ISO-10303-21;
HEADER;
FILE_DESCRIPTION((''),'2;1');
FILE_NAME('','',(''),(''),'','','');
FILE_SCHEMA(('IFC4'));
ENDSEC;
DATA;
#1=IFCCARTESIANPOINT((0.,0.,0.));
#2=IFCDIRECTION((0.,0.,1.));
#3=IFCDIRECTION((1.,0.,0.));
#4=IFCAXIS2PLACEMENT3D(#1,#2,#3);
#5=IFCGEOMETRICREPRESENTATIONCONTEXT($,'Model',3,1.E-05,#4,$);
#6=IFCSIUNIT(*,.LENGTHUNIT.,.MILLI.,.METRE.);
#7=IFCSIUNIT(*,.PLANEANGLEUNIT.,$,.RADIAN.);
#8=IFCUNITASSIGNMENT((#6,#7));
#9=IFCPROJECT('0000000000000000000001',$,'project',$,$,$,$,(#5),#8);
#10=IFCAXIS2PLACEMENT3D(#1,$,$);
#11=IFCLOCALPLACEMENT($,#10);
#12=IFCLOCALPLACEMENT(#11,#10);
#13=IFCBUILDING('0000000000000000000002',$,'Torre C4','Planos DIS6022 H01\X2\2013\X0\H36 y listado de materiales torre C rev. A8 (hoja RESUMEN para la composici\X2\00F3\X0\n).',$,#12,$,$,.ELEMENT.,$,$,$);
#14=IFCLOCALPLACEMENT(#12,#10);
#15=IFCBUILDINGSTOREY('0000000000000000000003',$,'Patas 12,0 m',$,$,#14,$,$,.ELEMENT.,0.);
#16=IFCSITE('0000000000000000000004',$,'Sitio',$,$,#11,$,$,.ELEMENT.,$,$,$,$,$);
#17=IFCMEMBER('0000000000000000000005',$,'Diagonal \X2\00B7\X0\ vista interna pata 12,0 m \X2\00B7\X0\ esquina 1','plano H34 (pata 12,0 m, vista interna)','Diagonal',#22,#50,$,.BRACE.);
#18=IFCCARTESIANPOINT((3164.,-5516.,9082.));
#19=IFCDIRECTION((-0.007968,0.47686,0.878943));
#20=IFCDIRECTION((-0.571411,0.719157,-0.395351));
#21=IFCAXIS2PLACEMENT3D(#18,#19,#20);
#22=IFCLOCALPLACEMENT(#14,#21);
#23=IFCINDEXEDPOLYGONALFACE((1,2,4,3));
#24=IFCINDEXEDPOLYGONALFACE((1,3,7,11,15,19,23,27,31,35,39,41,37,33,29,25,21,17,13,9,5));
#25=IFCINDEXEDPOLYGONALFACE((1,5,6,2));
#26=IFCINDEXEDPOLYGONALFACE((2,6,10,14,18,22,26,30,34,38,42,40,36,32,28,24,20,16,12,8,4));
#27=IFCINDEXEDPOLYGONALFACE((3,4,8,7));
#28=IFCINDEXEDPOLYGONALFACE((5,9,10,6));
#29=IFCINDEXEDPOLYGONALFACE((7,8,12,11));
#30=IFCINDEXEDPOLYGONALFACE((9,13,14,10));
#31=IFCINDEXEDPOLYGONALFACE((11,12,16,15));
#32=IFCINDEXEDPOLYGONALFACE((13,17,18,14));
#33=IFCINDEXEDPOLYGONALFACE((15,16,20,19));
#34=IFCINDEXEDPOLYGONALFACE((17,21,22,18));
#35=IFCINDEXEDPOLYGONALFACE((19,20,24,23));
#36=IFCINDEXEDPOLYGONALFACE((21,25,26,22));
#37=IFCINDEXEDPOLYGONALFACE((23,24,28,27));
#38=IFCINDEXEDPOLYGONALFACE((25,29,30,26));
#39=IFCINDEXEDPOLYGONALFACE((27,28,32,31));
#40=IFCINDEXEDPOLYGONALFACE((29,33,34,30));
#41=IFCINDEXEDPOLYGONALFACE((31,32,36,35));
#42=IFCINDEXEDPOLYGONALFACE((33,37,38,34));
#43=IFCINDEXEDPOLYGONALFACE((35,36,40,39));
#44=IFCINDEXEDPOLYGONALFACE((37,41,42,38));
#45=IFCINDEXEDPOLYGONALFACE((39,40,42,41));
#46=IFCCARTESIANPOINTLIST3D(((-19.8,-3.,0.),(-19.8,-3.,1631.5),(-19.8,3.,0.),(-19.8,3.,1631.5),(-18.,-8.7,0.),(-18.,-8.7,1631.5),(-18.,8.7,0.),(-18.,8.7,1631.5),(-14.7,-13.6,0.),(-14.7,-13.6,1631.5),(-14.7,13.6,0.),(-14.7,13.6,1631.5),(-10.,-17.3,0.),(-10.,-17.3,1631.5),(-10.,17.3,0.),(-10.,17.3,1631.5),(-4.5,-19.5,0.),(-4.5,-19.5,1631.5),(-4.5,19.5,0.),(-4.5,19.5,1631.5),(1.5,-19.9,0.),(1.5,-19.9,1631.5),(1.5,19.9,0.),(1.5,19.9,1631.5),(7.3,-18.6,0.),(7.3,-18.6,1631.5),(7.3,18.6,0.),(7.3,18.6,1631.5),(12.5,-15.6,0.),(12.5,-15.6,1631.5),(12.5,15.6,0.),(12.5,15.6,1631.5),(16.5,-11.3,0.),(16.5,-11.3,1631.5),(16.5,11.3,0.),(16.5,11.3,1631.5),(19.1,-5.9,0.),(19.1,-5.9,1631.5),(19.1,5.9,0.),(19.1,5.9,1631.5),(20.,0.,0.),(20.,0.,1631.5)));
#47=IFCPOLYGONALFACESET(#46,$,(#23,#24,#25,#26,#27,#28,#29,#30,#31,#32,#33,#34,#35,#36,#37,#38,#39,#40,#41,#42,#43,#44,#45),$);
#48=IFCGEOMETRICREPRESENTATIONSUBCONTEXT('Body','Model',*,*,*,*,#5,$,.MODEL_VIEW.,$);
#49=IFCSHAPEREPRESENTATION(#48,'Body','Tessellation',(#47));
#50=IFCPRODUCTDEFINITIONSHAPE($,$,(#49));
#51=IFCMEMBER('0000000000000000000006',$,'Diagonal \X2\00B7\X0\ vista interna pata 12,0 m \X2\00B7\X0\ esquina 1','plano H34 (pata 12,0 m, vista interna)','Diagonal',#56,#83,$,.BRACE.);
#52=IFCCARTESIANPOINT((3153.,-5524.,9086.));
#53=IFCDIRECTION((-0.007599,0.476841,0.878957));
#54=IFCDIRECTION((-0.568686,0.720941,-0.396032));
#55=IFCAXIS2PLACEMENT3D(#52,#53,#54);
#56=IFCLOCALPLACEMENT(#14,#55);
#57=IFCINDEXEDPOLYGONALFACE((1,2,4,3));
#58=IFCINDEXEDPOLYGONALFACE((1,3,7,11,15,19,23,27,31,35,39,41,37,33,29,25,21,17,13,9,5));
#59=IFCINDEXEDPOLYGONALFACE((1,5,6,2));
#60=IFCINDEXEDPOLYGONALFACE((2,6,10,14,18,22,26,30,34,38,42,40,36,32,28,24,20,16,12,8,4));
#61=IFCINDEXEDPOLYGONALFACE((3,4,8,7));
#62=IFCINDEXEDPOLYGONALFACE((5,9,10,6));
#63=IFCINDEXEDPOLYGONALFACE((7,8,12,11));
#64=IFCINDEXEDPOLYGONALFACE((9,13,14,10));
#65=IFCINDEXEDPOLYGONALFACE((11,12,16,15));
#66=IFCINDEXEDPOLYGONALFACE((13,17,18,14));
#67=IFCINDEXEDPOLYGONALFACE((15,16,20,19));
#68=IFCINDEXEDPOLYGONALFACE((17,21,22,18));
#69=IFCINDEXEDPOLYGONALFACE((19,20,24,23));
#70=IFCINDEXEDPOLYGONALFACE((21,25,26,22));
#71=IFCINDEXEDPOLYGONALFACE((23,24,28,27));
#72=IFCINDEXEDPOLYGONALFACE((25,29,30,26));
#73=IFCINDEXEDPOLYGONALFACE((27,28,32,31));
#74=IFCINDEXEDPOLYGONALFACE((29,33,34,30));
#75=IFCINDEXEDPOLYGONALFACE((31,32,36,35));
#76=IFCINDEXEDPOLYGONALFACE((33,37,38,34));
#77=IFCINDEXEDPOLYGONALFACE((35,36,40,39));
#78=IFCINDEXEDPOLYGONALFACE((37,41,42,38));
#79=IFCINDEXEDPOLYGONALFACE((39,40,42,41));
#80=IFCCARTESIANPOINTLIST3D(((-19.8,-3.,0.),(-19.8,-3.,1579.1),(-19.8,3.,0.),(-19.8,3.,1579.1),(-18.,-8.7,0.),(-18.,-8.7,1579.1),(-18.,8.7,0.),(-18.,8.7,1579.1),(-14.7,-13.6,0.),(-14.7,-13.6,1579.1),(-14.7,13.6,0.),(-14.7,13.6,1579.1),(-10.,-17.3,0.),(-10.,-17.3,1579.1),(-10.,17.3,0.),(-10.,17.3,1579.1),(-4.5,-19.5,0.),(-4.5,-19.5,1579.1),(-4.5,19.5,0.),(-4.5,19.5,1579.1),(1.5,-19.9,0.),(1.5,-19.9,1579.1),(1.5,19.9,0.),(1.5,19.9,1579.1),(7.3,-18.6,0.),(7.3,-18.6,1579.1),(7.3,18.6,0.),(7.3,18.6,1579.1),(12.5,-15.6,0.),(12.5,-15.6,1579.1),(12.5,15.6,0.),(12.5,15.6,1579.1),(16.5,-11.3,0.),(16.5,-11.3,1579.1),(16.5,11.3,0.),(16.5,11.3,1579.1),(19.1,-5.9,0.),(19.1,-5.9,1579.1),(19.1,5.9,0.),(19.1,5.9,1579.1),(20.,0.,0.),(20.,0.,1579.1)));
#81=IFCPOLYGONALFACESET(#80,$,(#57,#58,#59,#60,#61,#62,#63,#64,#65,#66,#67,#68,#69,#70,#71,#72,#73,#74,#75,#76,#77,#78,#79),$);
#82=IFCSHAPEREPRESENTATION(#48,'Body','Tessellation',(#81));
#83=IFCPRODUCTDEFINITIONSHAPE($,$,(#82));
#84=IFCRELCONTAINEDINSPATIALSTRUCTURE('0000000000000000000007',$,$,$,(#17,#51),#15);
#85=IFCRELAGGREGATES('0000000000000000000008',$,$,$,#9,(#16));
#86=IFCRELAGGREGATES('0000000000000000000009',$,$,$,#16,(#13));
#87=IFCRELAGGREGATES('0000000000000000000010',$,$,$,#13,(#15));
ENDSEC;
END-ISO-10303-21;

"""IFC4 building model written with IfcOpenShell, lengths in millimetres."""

from ifc_helpers import new_model, si_unit, frame, origin, origin_with_axes, place, context, subcontext, project, spatial, circle, extrude, element, save


model = new_model("IFC4")

# Units and contexts
model_context = context("Model", 3, precision=1e-05, world=origin_with_axes())
body_context = subcontext(model_context, "Body", "Model", "MODEL_VIEW")
ifc_project = project(units=[si_unit("LENGTHUNIT", "METRE", prefix="MILLI"), si_unit("PLANEANGLEUNIT", "RADIAN")], contexts=[model_context])

# Site, building, storey
site_placement = place(None, origin())
site = spatial("IfcSite", under=ifc_project, at=site_placement, Name="Sitio", CompositionType="ELEMENT")
building_placement = place(site_placement, origin())
building = spatial("IfcBuilding", under=site, at=building_placement, Name="Torre C4", Description="Planos DIS6022 H01–H36 y listado de materiales torre C rev. A8 (hoja RESUMEN para la composición).", CompositionType="ELEMENT")
storey_placement = place(building_placement, origin())
storey = spatial("IfcBuildingStorey", under=building, at=storey_placement, Name="Patas 12,0 m", CompositionType="ELEMENT", Elevation=0.0)

# Members
member_1_placement = place(storey_placement, frame((3164.0, -5516.0, 9082.0), z_axis=(-0.007968, 0.47686, 0.878943), x_axis=(-0.571411, 0.719157, -0.395351)))
element("IfcMember", 1, at=member_1_placement, inside=storey, Name="Diagonal · vista interna pata 12,0 m · esquina 1", Description="plano H34 (pata 12,0 m, vista interna)", ObjectType="Diagonal", PredefinedType="BRACE", context=body_context, shape_type="SweptSolid", body=[
    extrude(circle(Radius=20.0), None, (0.0, 0.0, 1.0), 1631.5),
])
member_2_placement = place(storey_placement, frame((3153.0, -5524.0, 9086.0), z_axis=(-0.007599, 0.476841, 0.878957), x_axis=(-0.568686, 0.720941, -0.396032)))
element("IfcMember", 2, at=member_2_placement, inside=storey, Name="Diagonal · vista interna pata 12,0 m · esquina 1", Description="plano H34 (pata 12,0 m, vista interna)", ObjectType="Diagonal", PredefinedType="BRACE", context=body_context, shape_type="SweptSolid", body=[
    extrude(circle(Radius=20.0), None, (0.0, 0.0, 1.0), 1579.1),
])

save(model, "model.ifc")
